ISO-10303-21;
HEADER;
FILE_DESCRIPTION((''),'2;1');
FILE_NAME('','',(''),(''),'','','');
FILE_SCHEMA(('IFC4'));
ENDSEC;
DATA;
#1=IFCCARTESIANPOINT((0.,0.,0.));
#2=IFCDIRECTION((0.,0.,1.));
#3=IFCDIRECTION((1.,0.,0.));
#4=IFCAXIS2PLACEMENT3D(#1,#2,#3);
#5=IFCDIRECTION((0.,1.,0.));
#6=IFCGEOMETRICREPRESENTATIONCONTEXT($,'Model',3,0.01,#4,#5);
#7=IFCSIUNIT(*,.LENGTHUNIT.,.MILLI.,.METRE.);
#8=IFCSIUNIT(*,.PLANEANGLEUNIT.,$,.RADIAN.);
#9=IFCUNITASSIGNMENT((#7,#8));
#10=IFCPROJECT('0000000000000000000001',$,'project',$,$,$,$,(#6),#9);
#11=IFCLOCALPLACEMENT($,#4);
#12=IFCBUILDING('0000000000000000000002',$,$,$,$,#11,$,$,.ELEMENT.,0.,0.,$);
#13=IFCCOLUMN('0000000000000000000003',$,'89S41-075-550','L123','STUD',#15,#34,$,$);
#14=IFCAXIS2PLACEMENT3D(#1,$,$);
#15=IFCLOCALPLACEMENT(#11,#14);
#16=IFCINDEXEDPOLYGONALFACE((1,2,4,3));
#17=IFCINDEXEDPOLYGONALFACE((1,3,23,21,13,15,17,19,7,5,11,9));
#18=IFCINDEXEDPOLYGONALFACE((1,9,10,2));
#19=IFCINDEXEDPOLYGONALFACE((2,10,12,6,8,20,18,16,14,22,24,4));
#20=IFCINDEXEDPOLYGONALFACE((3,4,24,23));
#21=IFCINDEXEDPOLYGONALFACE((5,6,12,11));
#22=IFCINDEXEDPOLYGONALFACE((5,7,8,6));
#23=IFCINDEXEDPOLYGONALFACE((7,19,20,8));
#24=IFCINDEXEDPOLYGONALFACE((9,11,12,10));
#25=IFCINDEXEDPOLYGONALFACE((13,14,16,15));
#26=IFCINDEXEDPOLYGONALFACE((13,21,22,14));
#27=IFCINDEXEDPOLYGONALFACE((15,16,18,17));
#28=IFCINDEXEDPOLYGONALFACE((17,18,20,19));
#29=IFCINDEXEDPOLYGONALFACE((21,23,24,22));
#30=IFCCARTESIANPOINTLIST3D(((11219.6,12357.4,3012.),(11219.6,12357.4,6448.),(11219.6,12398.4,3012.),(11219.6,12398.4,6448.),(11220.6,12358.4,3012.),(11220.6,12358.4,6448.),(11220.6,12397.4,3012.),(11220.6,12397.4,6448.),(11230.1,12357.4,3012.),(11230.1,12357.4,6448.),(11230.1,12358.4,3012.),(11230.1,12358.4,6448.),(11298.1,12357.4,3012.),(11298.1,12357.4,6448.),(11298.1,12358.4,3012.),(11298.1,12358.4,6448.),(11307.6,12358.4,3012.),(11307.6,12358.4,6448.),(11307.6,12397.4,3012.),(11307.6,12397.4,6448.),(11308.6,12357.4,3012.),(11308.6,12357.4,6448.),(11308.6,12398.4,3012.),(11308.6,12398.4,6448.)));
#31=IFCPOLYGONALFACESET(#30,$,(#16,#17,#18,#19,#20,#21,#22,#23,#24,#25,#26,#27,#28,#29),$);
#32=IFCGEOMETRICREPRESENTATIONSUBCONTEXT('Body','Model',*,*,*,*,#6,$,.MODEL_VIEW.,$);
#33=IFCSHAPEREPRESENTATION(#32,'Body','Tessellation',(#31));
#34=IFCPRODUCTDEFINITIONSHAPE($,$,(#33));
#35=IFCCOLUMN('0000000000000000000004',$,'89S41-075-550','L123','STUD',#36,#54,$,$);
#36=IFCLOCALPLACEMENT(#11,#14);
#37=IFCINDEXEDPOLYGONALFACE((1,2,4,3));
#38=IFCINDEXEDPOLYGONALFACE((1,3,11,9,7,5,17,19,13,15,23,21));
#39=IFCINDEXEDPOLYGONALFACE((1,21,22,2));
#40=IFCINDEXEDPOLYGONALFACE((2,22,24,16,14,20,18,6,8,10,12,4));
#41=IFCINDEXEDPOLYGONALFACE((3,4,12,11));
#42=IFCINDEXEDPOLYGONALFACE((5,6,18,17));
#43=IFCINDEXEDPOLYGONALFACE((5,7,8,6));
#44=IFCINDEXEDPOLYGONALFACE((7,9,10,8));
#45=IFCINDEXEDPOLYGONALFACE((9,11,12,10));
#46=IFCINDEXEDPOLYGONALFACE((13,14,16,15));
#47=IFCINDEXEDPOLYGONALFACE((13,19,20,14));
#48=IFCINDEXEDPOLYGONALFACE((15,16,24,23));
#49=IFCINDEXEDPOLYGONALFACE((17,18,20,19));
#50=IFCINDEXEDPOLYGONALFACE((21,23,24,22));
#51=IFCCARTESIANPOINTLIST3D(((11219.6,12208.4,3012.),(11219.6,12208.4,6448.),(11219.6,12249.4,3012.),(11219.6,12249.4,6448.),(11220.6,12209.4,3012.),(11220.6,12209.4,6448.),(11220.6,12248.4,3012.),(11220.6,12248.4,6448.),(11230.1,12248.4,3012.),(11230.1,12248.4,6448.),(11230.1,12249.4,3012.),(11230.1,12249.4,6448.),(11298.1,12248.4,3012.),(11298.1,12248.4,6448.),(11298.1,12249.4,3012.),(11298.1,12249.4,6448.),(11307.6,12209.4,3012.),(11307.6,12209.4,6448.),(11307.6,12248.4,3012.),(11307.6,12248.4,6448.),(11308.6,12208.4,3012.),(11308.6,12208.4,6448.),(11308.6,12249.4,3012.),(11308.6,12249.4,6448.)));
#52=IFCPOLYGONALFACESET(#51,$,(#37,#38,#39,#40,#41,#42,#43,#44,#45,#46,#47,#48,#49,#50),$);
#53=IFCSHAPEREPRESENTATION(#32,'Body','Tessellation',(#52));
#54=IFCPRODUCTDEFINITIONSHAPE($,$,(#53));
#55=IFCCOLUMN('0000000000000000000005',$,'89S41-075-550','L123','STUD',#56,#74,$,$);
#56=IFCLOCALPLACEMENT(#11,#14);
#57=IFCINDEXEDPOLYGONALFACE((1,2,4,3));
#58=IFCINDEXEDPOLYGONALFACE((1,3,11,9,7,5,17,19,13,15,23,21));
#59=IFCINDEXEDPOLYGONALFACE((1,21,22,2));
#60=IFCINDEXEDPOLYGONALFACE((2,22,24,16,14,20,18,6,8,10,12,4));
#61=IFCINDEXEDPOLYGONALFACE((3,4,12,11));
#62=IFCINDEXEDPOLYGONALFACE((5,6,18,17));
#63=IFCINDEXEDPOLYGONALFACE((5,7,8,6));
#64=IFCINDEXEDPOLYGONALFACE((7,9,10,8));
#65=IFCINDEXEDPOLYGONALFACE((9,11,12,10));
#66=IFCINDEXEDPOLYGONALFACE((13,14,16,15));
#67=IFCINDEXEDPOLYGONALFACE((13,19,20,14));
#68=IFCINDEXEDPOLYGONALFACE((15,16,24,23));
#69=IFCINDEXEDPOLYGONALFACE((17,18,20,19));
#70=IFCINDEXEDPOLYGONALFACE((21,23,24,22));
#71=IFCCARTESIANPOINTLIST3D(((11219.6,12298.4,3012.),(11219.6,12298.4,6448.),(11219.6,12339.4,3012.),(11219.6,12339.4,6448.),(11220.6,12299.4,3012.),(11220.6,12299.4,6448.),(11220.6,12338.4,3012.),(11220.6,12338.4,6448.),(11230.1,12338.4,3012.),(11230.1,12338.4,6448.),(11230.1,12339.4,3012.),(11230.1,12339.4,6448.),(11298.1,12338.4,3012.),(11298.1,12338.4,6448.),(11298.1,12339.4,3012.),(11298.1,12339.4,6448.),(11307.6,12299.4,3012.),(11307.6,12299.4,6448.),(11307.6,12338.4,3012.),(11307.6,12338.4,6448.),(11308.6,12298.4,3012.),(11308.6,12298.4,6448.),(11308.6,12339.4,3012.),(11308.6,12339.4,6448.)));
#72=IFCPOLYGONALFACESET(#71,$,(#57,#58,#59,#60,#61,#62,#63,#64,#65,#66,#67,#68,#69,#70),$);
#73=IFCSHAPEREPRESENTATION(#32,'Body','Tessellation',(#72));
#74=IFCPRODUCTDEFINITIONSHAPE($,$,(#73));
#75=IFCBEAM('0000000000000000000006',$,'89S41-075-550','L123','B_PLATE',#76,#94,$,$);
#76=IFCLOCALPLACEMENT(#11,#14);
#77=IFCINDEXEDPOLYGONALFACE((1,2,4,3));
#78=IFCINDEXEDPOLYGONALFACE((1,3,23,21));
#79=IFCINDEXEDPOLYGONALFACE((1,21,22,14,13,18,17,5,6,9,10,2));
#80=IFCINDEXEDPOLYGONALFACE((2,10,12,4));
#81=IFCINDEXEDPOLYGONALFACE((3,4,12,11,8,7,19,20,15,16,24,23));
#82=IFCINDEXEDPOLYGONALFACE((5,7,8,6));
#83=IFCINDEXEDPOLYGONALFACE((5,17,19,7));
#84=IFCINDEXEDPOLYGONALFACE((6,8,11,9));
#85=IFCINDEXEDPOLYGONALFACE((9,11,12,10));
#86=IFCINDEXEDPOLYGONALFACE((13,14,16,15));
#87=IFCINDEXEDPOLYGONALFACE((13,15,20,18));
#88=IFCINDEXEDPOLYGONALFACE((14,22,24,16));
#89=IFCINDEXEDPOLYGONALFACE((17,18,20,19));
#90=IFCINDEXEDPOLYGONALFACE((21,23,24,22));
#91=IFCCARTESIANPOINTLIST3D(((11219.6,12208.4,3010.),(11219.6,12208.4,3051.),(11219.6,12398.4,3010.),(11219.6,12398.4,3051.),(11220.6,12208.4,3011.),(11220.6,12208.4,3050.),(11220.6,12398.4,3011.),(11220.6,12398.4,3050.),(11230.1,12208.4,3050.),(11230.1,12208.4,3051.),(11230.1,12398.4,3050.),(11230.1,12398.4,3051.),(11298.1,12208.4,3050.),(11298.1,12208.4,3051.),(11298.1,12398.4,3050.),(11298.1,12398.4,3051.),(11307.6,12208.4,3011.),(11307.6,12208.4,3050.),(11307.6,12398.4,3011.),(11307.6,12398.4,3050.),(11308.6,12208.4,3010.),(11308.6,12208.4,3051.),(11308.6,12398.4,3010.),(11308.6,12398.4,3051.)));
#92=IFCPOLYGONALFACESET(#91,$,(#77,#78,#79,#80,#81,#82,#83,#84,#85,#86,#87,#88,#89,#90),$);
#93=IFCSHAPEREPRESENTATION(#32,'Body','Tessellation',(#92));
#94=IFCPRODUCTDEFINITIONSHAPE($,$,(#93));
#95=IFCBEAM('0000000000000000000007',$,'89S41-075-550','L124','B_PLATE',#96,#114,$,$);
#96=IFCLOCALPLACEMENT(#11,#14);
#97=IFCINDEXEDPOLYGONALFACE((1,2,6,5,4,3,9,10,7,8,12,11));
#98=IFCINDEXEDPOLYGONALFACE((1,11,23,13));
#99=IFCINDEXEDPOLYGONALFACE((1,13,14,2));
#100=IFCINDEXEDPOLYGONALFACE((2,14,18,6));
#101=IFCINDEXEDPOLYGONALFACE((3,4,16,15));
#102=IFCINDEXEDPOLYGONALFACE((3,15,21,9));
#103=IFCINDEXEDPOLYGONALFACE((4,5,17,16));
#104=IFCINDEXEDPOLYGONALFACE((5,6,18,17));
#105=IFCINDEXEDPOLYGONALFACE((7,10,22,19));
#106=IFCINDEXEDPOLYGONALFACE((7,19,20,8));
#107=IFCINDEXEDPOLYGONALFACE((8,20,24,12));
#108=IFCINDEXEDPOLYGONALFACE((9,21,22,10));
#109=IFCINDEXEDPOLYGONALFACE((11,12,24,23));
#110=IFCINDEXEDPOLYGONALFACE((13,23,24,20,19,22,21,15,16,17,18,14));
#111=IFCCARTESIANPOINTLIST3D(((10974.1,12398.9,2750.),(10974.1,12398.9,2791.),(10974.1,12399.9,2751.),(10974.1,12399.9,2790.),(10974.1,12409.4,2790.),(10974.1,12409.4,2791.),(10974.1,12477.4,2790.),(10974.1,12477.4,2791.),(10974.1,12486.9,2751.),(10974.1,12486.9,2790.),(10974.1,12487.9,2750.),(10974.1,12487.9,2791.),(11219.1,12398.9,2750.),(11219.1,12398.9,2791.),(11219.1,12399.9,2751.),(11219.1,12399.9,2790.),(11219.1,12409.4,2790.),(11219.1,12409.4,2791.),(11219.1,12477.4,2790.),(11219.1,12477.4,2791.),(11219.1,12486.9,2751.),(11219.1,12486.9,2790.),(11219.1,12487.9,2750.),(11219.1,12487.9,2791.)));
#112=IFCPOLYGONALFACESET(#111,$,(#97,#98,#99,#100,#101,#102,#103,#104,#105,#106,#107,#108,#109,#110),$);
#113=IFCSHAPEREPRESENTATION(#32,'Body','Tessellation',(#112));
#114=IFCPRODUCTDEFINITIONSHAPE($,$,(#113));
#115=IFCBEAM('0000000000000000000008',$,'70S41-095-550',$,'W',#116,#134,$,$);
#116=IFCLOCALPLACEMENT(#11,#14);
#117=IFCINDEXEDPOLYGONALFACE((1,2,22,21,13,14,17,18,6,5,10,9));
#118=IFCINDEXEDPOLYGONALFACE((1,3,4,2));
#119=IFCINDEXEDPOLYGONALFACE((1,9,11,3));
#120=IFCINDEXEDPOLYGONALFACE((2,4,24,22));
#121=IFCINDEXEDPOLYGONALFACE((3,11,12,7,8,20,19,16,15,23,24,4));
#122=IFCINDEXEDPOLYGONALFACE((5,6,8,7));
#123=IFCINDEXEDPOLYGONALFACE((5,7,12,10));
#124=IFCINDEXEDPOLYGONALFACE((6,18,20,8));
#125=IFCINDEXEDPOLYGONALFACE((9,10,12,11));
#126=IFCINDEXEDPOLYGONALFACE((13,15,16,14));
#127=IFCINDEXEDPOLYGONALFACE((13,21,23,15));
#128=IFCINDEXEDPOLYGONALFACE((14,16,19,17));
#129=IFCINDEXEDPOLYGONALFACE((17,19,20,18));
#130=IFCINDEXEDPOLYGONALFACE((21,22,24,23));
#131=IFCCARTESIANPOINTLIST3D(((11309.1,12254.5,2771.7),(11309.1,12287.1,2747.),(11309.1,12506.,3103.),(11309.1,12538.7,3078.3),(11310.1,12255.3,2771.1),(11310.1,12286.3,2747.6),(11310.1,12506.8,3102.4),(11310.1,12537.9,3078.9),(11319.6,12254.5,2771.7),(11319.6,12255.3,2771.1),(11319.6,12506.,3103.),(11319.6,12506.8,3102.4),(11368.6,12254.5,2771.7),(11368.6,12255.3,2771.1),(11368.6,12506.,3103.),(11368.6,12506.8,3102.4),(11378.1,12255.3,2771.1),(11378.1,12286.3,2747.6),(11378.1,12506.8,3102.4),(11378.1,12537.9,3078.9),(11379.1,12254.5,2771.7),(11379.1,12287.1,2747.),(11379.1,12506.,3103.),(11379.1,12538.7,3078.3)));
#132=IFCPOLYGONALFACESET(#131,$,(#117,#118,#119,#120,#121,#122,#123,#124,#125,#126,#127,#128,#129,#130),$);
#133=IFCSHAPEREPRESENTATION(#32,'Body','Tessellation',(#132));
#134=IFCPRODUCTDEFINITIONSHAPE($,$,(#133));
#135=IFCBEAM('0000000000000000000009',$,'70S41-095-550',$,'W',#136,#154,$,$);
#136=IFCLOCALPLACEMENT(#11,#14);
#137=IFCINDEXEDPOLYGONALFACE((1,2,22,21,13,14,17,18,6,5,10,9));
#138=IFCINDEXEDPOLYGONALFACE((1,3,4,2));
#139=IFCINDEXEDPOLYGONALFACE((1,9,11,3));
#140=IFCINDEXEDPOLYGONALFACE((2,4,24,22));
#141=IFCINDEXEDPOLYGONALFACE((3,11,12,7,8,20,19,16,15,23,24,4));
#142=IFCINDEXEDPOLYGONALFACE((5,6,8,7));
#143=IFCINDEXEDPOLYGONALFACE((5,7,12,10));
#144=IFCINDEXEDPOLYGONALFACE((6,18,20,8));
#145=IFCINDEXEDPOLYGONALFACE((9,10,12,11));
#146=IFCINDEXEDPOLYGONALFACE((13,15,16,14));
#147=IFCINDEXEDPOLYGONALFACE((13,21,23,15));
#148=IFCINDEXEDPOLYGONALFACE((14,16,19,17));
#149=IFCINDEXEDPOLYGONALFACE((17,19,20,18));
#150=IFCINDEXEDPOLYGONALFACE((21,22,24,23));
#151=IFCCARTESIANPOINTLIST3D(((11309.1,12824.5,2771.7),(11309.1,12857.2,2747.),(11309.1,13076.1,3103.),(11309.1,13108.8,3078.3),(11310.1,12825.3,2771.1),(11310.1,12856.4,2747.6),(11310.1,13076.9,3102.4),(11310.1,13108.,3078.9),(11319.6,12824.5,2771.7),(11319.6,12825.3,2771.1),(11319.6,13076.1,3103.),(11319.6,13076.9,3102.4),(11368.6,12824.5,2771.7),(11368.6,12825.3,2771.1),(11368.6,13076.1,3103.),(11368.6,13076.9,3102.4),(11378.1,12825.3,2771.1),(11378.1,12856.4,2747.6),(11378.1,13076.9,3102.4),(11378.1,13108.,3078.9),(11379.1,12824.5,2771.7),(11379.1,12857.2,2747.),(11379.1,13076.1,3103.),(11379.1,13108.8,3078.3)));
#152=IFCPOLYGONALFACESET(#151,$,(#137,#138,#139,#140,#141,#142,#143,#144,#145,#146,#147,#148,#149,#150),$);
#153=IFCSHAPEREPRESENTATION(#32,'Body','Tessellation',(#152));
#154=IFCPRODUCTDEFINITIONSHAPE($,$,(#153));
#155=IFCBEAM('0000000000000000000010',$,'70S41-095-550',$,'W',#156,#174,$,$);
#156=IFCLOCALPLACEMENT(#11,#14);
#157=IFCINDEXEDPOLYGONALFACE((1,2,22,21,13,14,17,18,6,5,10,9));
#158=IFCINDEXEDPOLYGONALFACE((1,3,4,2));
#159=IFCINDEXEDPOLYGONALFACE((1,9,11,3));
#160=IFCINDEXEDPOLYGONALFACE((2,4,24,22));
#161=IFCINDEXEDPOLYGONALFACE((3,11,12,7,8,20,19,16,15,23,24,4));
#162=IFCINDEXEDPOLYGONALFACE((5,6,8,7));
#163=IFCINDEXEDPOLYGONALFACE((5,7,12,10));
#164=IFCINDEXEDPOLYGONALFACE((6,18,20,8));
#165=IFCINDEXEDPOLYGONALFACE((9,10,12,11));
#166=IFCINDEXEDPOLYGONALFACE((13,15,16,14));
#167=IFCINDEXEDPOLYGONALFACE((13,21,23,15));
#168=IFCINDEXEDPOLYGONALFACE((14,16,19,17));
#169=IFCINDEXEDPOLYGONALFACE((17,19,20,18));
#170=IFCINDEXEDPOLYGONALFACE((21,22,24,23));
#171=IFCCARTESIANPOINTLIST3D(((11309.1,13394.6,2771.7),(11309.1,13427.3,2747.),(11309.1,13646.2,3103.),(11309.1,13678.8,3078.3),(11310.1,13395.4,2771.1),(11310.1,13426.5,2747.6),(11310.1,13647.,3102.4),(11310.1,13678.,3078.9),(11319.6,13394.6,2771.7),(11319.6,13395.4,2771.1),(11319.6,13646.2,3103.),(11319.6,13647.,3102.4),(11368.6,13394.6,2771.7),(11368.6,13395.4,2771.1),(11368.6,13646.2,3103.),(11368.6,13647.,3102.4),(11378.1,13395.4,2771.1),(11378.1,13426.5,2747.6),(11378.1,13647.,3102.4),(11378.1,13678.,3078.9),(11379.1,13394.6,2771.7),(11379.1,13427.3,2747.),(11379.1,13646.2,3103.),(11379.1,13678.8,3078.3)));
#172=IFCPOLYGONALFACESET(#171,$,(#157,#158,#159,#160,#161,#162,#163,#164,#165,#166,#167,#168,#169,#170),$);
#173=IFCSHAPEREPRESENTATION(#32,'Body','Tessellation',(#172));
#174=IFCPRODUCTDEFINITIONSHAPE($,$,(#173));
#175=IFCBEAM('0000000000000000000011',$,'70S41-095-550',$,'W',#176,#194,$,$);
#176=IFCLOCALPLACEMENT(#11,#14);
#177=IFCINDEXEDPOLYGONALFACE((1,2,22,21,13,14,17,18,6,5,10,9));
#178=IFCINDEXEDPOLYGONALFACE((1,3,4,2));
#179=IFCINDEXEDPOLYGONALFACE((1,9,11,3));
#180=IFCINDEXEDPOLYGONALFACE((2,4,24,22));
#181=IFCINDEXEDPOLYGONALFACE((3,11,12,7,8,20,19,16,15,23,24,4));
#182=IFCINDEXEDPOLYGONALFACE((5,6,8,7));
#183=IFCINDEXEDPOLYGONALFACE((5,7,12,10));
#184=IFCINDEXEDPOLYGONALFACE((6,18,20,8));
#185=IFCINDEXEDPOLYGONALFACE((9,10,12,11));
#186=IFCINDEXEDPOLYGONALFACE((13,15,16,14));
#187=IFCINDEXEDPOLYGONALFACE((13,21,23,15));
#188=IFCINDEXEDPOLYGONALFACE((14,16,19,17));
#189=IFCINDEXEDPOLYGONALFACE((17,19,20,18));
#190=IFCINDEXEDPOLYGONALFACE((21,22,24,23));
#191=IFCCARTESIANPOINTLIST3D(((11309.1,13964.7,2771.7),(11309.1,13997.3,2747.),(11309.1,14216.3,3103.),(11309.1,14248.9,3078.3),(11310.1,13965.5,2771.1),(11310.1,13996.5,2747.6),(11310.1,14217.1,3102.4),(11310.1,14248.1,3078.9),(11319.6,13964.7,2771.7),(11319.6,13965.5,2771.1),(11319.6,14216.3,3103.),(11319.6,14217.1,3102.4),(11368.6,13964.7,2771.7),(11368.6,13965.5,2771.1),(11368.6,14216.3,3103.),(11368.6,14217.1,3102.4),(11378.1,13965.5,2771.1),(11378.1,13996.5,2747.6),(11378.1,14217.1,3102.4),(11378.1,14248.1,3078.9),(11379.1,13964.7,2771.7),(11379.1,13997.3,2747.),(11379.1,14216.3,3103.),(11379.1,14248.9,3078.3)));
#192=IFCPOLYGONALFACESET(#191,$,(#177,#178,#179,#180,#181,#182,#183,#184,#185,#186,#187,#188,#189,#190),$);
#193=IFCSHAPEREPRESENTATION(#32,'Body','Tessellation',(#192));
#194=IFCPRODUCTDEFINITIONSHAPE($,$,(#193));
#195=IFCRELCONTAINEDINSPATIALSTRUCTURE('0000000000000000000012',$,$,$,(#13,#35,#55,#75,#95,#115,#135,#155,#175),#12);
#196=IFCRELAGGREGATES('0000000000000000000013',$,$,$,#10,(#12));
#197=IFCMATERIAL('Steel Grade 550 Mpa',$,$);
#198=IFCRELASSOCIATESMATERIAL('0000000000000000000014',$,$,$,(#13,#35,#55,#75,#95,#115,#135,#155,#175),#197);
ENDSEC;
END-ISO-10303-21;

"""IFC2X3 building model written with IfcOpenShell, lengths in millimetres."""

from ifc_helpers import new_model, si_unit, direction, frame, origin, origin_with_axes, origin_2d_with_axis, place, context, subcontext, project, spatial, c_section, extrude, source, transform, mapped, material, element, save


model = new_model("IFC2X3")

# Units and contexts
model_context = context("Model", 3, precision=0.01, world=origin_with_axes(), true_north=direction((0.0, 1.0, 0.0)))
body_context = subcontext(model_context, "Body", "Model", "MODEL_VIEW")
ifc_project = project(units=[si_unit("LENGTHUNIT", "METRE", prefix="MILLI"), si_unit("PLANEANGLEUNIT", "RADIAN")], contexts=[model_context])

# Building
building_placement = place(None, origin_with_axes())
building = spatial("IfcBuilding", under=ifc_project, at=building_placement, CompositionType="ELEMENT", ElevationOfRefHeight=0.0, ElevationOfTerrain=0.0)

# Columns
ifc_material = material(Name="Steel Grade 550 Mpa")
shared_shape_1 = source(origin(), body_context, "Body", "SweptSolid", [
    extrude(c_section(Depth=89.0, Width=41.0, WallThickness=1.0, Girth=10.5, at=origin_2d_with_axis()), origin_with_axes(), (0.0, 0.0, 1.0), 3436.0),
])
column_1_placement = place(None, frame((11264.1, 12377.9, 3012.0), z_axis=(0.0, 0.0, 1.0), x_axis=(0.0, -1.0, 0.0)))
element("IfcColumn", 1, at=column_1_placement, inside=building, material=ifc_material, Name="89S41-075-550", Description="L123", ObjectType="STUD", context=body_context, shape_type="MappedRepresentation", body=[
    mapped(shared_shape_1, transform((0.0, 0.0, 0.0), scale=1.0)),
])
shared_shape_2 = source(origin(), body_context, "Body", "SweptSolid", [
    extrude(c_section(Depth=89.0, Width=41.0, WallThickness=1.0, Girth=10.5, at=origin_2d_with_axis()), origin_with_axes(), (0.0, 0.0, 1.0), 3436.0),
])
column_2_placement = place(None, frame((11264.1, 12228.9, 3012.0), z_axis=(0.0, 0.0, 1.0), x_axis=(0.0, 1.0, 0.0)))
element("IfcColumn", 2, at=column_2_placement, inside=building, material=ifc_material, Name="89S41-075-550", Description="L123", ObjectType="STUD", context=body_context, shape_type="MappedRepresentation", body=[
    mapped(shared_shape_2, transform((0.0, 0.0, 0.0), scale=1.0)),
])
shared_shape_3 = source(origin(), body_context, "Body", "SweptSolid", [
    extrude(c_section(Depth=89.0, Width=41.0, WallThickness=1.0, Girth=10.5, at=origin_2d_with_axis()), origin_with_axes(), (0.0, 0.0, 1.0), 3436.0),
])
column_3_placement = place(None, frame((11264.1, 12318.9, 3012.0), z_axis=(0.0, 0.0, 1.0), x_axis=(0.0, 1.0, 0.0)))
element("IfcColumn", 3, at=column_3_placement, inside=building, material=ifc_material, Name="89S41-075-550", Description="L123", ObjectType="STUD", context=body_context, shape_type="MappedRepresentation", body=[
    mapped(shared_shape_3, transform((0.0, 0.0, 0.0), scale=1.0)),
])

# Beams
shared_shape_4 = source(origin(), body_context, "Body", "SweptSolid", [
    extrude(c_section(Depth=89.0, Width=41.0, WallThickness=1.0, Girth=10.5, at=origin_2d_with_axis()), origin_with_axes(), (0.0, 0.0, 1.0), 190.0),
])
beam_1_placement = place(None, frame((11264.1, 12398.4, 3030.5), z_axis=(0.0, -1.0, 0.0), x_axis=(0.0, 0.0, 1.0)))
element("IfcBeam", 4, at=beam_1_placement, inside=building, material=ifc_material, Name="89S41-075-550", Description="L123", ObjectType="B_PLATE", context=body_context, shape_type="MappedRepresentation", body=[
    mapped(shared_shape_4, transform((0.0, 0.0, 0.0), scale=1.0)),
])
shared_shape_5 = source(origin(), body_context, "Body", "SweptSolid", [
    extrude(c_section(Depth=89.0, Width=41.0, WallThickness=1.0, Girth=10.5, at=origin_2d_with_axis()), origin_with_axes(), (0.0, 0.0, 1.0), 245.0),
])
beam_2_placement = place(None, frame((10974.1, 12443.4, 2770.5), z_axis=(1.0, 0.0, 0.0), x_axis=(0.0, 0.0, 1.0)))
element("IfcBeam", 5, at=beam_2_placement, inside=building, material=ifc_material, Name="89S41-075-550", Description="L124", ObjectType="B_PLATE", context=body_context, shape_type="MappedRepresentation", body=[
    mapped(shared_shape_5, transform((0.0, 0.0, 0.0), scale=1.0)),
])
shared_shape_6 = source(origin(), body_context, "Body", "SweptSolid", [
    extrude(c_section(Depth=70.0, Width=41.0, WallThickness=1.0, Girth=10.5, at=origin_2d_with_axis()), origin_with_axes(), (0.0, 0.0, 1.0), 416.0),
])
beam_3_placement = place(None, frame((11344.1, 12522.4, 3090.6), z_axis=(0.0, -0.604771, -0.796399), x_axis=(0.0, -0.796399, 0.604771)))
element("IfcBeam", 6, at=beam_3_placement, inside=building, material=ifc_material, Name="70S41-095-550", ObjectType="W", context=body_context, shape_type="MappedRepresentation", body=[
    mapped(shared_shape_6, transform((0.0, 0.0, 0.0), scale=1.0)),
])
shared_shape_7 = source(origin(), body_context, "Body", "SweptSolid", [
    extrude(c_section(Depth=70.0, Width=41.0, WallThickness=1.0, Girth=10.5, at=origin_2d_with_axis()), origin_with_axes(), (0.0, 0.0, 1.0), 416.0),
])
beam_4_placement = place(None, frame((11344.1, 13092.4, 3090.6), z_axis=(0.0, -0.604771, -0.796399), x_axis=(0.0, -0.796399, 0.604771)))
element("IfcBeam", 7, at=beam_4_placement, inside=building, material=ifc_material, Name="70S41-095-550", ObjectType="W", context=body_context, shape_type="MappedRepresentation", body=[
    mapped(shared_shape_7, transform((0.0, 0.0, 0.0), scale=1.0)),
])
shared_shape_8 = source(origin(), body_context, "Body", "SweptSolid", [
    extrude(c_section(Depth=70.0, Width=41.0, WallThickness=1.0, Girth=10.5, at=origin_2d_with_axis()), origin_with_axes(), (0.0, 0.0, 1.0), 416.0),
])
beam_5_placement = place(None, frame((11344.1, 13662.5, 3090.6), z_axis=(0.0, -0.604771, -0.796399), x_axis=(0.0, -0.796399, 0.604771)))
element("IfcBeam", 8, at=beam_5_placement, inside=building, material=ifc_material, Name="70S41-095-550", ObjectType="W", context=body_context, shape_type="MappedRepresentation", body=[
    mapped(shared_shape_8, transform((0.0, 0.0, 0.0), scale=1.0)),
])
shared_shape_9 = source(origin(), body_context, "Body", "SweptSolid", [
    extrude(c_section(Depth=70.0, Width=41.0, WallThickness=1.0, Girth=10.5, at=origin_2d_with_axis()), origin_with_axes(), (0.0, 0.0, 1.0), 416.0),
])
beam_6_placement = place(None, frame((11344.1, 14232.6, 3090.6), z_axis=(0.0, -0.604771, -0.796399), x_axis=(0.0, -0.796399, 0.604771)))
element("IfcBeam", 9, at=beam_6_placement, inside=building, material=ifc_material, Name="70S41-095-550", ObjectType="W", context=body_context, shape_type="MappedRepresentation", body=[
    mapped(shared_shape_9, transform((0.0, 0.0, 0.0), scale=1.0)),
])

save(model, "model.ifc")
